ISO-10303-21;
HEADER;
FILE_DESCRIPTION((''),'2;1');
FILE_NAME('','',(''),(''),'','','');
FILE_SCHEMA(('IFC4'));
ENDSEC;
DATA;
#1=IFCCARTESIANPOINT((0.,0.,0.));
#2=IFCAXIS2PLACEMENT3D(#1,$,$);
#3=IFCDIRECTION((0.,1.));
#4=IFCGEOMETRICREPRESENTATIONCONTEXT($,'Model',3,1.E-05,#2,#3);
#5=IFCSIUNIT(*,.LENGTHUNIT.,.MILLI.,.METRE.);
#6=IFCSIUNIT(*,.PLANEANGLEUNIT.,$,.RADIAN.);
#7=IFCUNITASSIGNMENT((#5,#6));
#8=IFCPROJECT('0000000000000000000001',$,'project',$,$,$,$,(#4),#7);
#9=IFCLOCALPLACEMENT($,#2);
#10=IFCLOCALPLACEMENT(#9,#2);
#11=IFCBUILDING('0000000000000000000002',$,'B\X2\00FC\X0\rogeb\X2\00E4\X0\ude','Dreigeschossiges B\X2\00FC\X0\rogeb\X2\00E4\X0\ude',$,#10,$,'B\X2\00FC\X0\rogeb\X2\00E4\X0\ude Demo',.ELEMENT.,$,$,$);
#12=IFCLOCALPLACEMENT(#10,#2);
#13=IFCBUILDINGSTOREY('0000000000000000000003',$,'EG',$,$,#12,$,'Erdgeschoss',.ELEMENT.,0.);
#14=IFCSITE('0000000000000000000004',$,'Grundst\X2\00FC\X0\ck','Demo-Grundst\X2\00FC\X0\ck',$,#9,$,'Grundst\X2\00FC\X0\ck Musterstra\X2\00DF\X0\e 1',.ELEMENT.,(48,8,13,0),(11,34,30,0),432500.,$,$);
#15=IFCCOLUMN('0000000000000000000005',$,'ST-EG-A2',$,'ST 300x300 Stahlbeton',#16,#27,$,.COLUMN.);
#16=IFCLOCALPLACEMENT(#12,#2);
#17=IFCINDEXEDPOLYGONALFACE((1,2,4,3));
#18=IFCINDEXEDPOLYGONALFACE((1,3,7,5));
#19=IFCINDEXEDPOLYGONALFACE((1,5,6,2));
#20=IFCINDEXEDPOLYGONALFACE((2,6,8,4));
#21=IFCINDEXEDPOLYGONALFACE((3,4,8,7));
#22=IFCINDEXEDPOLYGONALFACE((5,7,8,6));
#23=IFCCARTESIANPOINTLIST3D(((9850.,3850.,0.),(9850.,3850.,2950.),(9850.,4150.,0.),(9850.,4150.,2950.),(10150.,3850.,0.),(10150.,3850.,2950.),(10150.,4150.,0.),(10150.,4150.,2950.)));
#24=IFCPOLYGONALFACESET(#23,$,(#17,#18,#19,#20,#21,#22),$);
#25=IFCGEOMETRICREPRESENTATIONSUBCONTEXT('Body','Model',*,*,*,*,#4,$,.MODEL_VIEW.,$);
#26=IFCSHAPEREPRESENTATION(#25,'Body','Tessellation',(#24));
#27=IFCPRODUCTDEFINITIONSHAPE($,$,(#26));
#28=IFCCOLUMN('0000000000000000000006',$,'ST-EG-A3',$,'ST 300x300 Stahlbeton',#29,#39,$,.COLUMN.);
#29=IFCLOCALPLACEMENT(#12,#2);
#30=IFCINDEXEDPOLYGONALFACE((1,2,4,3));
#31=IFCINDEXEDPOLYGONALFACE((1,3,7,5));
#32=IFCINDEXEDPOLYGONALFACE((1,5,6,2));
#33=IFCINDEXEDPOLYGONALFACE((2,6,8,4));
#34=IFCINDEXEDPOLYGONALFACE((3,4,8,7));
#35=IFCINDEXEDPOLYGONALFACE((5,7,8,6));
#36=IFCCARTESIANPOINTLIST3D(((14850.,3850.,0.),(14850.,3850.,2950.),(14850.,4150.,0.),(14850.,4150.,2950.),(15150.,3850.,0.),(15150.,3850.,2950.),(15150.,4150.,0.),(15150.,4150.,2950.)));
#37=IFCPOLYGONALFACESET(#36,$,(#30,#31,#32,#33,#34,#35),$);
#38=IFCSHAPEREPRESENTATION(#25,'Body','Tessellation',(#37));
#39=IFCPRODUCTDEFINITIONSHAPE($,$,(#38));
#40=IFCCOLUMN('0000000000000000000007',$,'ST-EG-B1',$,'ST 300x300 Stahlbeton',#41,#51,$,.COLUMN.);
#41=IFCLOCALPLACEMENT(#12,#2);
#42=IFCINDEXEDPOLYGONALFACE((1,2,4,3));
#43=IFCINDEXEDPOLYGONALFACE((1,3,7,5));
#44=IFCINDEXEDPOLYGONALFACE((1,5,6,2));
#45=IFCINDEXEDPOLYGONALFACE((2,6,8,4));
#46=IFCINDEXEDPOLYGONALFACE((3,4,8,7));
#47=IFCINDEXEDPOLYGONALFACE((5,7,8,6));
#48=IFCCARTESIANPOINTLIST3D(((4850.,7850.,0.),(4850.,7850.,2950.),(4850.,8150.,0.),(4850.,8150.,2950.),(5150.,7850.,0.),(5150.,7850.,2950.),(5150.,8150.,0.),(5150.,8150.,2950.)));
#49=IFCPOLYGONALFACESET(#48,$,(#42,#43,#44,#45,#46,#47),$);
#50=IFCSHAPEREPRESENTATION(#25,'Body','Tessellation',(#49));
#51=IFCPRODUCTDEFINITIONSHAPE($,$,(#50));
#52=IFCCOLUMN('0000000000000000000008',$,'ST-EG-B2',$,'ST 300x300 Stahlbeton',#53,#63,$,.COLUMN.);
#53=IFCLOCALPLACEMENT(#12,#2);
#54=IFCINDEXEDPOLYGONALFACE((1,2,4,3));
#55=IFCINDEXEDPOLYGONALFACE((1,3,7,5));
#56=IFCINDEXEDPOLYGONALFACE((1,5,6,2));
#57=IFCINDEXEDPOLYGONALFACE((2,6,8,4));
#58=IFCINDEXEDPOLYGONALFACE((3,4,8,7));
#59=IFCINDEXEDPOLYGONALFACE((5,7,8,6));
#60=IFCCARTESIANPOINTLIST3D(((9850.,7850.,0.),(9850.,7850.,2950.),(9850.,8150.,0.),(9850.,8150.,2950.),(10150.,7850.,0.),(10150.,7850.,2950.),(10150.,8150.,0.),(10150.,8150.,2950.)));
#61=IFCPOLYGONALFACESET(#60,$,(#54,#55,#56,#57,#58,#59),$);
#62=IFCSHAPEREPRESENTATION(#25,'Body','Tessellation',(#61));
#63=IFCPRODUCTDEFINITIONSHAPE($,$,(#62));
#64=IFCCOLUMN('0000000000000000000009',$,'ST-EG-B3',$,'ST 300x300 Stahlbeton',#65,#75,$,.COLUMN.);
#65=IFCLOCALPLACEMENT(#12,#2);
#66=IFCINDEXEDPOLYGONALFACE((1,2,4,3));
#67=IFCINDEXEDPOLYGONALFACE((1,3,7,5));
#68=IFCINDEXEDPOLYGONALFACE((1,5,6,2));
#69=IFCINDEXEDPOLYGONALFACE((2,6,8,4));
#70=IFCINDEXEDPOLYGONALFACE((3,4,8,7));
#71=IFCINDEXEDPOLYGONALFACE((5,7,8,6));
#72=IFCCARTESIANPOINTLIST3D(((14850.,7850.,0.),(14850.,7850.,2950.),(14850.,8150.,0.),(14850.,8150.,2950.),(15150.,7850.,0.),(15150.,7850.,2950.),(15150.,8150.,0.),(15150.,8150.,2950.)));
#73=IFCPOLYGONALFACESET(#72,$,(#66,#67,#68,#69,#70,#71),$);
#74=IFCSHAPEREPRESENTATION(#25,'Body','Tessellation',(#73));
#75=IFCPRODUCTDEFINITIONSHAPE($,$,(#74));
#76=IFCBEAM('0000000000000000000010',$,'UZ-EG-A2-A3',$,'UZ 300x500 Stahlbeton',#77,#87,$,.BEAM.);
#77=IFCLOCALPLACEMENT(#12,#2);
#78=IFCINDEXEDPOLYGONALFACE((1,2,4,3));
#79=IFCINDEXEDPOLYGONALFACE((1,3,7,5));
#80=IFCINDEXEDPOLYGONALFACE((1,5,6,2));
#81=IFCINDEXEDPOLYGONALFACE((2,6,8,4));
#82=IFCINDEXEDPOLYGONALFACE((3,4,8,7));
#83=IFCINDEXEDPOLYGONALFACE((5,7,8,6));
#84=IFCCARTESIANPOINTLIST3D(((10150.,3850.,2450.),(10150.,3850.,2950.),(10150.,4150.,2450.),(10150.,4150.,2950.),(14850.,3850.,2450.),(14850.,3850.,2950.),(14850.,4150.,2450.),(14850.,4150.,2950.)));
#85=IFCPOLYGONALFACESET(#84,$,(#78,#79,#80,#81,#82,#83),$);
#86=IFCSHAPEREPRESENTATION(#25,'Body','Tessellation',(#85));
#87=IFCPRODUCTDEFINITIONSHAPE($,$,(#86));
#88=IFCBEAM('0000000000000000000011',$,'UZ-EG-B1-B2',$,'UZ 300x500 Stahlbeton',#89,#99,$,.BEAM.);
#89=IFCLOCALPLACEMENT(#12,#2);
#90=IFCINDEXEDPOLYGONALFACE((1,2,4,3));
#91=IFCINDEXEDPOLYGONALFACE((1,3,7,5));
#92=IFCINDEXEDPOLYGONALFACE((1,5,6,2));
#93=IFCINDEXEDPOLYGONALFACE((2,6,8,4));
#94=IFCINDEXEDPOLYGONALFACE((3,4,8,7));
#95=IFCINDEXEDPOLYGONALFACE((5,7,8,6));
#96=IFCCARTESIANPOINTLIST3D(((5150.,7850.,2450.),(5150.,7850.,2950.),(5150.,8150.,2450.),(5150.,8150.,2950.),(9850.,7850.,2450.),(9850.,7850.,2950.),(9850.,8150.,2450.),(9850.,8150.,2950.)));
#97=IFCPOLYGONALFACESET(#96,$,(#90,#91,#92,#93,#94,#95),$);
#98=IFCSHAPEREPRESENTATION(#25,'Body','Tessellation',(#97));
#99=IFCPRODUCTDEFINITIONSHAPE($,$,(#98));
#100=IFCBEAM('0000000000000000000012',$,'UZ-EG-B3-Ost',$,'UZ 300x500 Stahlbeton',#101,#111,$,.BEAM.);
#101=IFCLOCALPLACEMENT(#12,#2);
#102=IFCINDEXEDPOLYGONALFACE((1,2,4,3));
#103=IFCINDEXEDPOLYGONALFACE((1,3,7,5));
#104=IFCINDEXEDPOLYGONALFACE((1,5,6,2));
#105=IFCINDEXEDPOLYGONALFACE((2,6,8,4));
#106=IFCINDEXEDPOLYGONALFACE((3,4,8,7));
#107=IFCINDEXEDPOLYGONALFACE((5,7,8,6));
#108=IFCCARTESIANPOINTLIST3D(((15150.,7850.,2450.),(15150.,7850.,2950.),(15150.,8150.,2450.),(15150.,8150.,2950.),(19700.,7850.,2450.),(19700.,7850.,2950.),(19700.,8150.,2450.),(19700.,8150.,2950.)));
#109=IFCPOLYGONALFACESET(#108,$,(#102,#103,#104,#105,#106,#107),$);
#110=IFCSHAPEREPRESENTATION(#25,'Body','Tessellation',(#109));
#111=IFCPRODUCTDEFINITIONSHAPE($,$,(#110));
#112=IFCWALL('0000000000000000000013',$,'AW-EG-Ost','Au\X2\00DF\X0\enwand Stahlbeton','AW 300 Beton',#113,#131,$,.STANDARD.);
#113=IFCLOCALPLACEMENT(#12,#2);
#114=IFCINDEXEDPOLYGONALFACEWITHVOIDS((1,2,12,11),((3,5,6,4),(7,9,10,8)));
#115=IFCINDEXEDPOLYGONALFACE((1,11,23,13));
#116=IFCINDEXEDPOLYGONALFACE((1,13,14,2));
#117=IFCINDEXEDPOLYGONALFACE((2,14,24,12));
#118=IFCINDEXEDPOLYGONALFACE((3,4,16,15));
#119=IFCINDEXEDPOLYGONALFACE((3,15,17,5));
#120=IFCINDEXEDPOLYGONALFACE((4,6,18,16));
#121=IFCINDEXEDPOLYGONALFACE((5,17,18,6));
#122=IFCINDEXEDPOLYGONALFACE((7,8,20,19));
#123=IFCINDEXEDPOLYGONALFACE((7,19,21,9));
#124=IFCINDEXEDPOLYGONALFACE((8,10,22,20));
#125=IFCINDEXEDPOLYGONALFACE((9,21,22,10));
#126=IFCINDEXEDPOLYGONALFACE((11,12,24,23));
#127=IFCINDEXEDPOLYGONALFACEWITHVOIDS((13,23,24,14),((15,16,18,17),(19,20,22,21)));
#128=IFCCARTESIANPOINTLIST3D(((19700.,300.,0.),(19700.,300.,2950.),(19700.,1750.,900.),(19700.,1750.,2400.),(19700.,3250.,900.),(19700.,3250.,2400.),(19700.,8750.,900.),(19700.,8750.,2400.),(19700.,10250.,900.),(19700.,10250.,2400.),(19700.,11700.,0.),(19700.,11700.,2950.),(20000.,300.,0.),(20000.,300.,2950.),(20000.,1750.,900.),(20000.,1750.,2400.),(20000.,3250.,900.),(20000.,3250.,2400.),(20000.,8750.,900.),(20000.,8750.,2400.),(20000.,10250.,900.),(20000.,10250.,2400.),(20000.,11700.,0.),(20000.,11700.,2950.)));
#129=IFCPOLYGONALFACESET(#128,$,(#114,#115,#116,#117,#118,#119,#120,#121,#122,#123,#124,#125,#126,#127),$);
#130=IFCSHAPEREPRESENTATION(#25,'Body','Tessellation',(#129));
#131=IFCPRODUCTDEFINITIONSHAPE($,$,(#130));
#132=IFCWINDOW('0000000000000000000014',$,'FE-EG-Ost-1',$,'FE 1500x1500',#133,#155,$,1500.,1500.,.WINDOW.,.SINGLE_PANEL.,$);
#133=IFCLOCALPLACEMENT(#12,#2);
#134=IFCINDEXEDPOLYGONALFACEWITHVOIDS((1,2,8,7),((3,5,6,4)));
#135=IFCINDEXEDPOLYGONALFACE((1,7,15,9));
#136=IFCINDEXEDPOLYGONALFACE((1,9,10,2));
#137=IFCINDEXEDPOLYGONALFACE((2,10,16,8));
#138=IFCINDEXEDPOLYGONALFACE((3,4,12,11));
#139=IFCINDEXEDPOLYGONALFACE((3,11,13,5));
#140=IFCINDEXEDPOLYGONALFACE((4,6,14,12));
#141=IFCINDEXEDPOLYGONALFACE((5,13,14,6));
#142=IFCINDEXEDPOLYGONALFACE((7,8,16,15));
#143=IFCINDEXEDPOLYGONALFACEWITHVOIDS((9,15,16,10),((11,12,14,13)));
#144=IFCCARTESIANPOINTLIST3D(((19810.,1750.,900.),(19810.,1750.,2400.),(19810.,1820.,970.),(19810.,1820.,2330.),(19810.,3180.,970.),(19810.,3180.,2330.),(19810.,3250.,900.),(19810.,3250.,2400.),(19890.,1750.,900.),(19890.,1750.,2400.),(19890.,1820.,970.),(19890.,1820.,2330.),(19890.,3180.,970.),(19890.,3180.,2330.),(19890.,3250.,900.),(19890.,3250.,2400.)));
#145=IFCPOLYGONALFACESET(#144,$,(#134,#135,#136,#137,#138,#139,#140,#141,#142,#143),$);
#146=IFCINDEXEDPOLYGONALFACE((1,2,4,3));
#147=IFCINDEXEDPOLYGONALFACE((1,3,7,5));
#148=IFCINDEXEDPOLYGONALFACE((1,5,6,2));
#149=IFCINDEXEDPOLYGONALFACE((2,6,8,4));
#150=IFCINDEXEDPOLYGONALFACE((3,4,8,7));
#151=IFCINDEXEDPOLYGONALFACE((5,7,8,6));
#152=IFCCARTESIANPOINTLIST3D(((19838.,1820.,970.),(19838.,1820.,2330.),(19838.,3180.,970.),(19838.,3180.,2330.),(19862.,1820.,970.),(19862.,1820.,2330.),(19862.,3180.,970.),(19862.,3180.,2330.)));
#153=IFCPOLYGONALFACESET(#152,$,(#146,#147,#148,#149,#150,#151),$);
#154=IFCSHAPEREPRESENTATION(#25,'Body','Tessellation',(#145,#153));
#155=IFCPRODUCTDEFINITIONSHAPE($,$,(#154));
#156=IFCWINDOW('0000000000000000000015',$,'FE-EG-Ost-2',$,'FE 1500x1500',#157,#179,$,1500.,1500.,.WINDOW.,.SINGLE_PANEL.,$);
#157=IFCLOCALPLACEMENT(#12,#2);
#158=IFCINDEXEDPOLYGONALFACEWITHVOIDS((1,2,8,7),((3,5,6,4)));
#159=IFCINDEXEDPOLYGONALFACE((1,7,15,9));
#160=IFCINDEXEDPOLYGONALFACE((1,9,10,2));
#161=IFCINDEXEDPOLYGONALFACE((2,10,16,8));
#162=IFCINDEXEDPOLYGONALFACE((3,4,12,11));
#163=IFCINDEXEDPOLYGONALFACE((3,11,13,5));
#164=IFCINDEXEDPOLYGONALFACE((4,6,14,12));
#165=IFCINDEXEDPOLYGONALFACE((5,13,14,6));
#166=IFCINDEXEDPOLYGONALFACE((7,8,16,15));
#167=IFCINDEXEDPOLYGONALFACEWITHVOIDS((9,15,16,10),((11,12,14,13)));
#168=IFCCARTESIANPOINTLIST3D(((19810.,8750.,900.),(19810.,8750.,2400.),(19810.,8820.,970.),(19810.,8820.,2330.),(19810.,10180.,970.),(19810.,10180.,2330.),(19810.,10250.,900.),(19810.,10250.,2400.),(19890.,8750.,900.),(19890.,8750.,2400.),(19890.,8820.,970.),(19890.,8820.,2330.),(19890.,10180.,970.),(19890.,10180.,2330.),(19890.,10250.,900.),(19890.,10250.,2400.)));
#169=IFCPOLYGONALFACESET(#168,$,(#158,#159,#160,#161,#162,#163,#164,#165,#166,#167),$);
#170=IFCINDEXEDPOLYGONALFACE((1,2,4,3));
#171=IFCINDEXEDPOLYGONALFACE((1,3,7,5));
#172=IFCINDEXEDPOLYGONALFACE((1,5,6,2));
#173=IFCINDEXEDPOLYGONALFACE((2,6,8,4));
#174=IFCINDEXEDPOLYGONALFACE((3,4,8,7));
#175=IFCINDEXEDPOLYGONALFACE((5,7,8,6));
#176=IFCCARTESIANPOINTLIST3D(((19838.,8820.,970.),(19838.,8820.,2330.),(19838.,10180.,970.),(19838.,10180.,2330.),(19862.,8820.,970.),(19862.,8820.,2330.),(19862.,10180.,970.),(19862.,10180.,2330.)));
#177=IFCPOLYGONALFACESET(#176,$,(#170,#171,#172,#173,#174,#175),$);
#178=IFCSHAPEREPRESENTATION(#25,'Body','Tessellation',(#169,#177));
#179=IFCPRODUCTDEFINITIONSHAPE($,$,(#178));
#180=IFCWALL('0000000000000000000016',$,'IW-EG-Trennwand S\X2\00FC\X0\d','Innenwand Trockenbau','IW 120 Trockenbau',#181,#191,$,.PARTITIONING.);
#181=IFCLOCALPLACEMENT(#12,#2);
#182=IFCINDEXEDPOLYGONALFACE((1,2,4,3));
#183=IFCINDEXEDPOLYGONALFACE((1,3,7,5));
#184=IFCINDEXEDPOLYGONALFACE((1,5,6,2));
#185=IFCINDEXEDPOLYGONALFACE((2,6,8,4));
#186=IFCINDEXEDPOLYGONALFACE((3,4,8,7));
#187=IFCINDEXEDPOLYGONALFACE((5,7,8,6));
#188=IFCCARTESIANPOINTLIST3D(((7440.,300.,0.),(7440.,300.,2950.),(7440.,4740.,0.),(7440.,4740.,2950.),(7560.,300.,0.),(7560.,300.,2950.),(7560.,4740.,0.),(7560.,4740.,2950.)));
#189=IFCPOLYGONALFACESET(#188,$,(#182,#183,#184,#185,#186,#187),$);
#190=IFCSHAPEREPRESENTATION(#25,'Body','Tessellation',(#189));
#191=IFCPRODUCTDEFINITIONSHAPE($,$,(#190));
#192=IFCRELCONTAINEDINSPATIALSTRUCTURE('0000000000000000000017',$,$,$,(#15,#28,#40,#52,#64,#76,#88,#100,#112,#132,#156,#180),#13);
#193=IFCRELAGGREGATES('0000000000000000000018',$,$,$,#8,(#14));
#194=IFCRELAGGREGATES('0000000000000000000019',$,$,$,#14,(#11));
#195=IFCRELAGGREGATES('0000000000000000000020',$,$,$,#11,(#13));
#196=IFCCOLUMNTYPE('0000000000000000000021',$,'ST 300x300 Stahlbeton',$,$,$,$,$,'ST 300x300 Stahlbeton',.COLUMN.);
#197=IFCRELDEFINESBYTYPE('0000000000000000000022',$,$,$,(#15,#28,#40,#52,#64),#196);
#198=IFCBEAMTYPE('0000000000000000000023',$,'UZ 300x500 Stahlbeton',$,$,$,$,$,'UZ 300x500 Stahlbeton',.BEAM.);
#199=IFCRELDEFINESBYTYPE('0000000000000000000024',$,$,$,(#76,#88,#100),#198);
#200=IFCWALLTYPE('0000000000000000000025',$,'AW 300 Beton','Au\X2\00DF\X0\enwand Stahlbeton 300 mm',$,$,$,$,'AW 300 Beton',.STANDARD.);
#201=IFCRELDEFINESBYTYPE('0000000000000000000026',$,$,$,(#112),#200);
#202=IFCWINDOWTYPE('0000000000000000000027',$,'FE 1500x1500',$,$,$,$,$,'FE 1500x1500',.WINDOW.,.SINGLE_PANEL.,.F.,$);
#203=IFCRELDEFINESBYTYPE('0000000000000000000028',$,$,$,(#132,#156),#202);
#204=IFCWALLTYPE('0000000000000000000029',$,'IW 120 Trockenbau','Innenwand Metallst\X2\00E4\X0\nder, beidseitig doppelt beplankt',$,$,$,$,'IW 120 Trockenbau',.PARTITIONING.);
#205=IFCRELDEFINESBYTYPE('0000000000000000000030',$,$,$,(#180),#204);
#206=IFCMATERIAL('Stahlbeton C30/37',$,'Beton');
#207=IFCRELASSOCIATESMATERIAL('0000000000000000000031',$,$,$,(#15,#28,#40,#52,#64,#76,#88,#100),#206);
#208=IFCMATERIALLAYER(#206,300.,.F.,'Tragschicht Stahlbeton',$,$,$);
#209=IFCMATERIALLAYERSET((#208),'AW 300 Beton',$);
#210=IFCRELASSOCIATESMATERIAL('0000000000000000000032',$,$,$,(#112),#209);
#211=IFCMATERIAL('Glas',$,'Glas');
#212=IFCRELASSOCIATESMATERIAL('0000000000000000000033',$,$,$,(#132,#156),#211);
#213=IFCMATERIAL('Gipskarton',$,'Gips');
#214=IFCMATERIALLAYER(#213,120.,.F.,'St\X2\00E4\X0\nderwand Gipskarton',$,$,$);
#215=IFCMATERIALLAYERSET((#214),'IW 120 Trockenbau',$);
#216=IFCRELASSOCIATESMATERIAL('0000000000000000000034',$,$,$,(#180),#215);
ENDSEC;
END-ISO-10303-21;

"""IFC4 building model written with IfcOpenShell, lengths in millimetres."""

from ifc_helpers import new_model, si_unit, direction, frame, frame_2d, origin, origin_2d, place, context, subcontext, project, spatial, polyline, rectangle, outline, extrude, material, layer, layer_set, layer_usage, type_object, element, fill, save


model = new_model("IFC4")

# Units and contexts
model_context = context("Model", 3, precision=1e-05, world=origin(), true_north=direction((0.0, 1.0)))
body_context = subcontext(model_context, "Body", "Model", "MODEL_VIEW")
ifc_project = project(units=[si_unit("LENGTHUNIT", "METRE", prefix="MILLI"), si_unit("PLANEANGLEUNIT", "RADIAN")], contexts=[model_context])

# Site, building, storey
site_placement = place(None, origin())
site = spatial("IfcSite", under=ifc_project, at=site_placement, Name="Grundstück", Description="Demo-Grundstück", LongName="Grundstück Musterstraße 1", CompositionType="ELEMENT", RefLatitude=(48, 8, 13, 0), RefLongitude=(11, 34, 30, 0), RefElevation=432500.0)
building_placement = place(site_placement, origin())
building = spatial("IfcBuilding", under=site, at=building_placement, Name="Bürogebäude", Description="Dreigeschossiges Bürogebäude", LongName="Bürogebäude Demo", CompositionType="ELEMENT")
storey_placement = place(building_placement, origin())
storey = spatial("IfcBuildingStorey", under=building, at=storey_placement, Name="EG", LongName="Erdgeschoss", CompositionType="ELEMENT", Elevation=0.0)

# Columns
ifc_material_1 = material(Name="Stahlbeton C30/37", Category="Beton")
column_type = type_object("IfcColumnType", Name="ST 300x300 Stahlbeton", ElementType="ST 300x300 Stahlbeton", PredefinedType="COLUMN")
for number, where, name in (
    (1, (10000.0, 4000.0, 0.0), "ST-EG-A2"),
    (2, (15000.0, 4000.0, 0.0), "ST-EG-A3"),
    (3, (5000.0, 8000.0, 0.0), "ST-EG-B1"),
    (4, (10000.0, 8000.0, 0.0), "ST-EG-B2"),
    (5, (15000.0, 8000.0, 0.0), "ST-EG-B3"),
):
    element("IfcColumn", number, at=place(storey_placement, frame(where)), inside=storey, type_object=column_type, material=ifc_material_1, Name=name, ObjectType="ST 300x300 Stahlbeton", PredefinedType="COLUMN", context=body_context, shape_type="SweptSolid", body=[
        extrude(rectangle(XDim=300.0, YDim=300.0, at=origin_2d()), origin(), (0.0, 0.0, 1.0), 2950.0),
    ])

# Beams
beam_type = type_object("IfcBeamType", Name="UZ 300x500 Stahlbeton", ElementType="UZ 300x500 Stahlbeton", PredefinedType="BEAM")
for number, where, name in (
    (6, (10150.0, 4000.0, 2700.0), "UZ-EG-A2-A3"),
    (7, (5150.0, 8000.0, 2700.0), "UZ-EG-B1-B2"),
):
    element("IfcBeam", number, at=place(storey_placement, frame(where)), inside=storey, type_object=beam_type, material=ifc_material_1, Name=name, ObjectType="UZ 300x500 Stahlbeton", PredefinedType="BEAM", context=body_context, shape_type="SweptSolid", body=[
        extrude(rectangle(XDim=300.0, YDim=500.0, at=origin_2d()), frame((0.0, 0.0, 0.0), z_axis=(1.0, 0.0, 0.0), x_axis=(0.0, 1.0, 0.0)), (0.0, 0.0, 1.0), 4700.0),
    ])
beam_placement = place(storey_placement, frame((15150.0, 8000.0, 2700.0)))
element("IfcBeam", 8, at=beam_placement, inside=storey, type_object=beam_type, material=ifc_material_1, Name="UZ-EG-B3-Ost", ObjectType="UZ 300x500 Stahlbeton", PredefinedType="BEAM", context=body_context, shape_type="SweptSolid", body=[
    extrude(rectangle(XDim=300.0, YDim=500.0, at=origin_2d()), frame((0.0, 0.0, 0.0), z_axis=(1.0, 0.0, 0.0), x_axis=(0.0, 1.0, 0.0)), (0.0, 0.0, 1.0), 4550.0),
])

# Wall, openings, windows
ifc_layer_1 = layer(ifc_material_1, 300.0, ventilated=False, Name="Tragschicht Stahlbeton")
ifc_layer_set_1 = layer_set([ifc_layer_1], Name="AW 300 Beton")
ifc_layer_usage_1 = layer_usage(ifc_layer_set_1, "AXIS2", "POSITIVE", -150.0)
wall_type_1 = type_object("IfcWallType", Name="AW 300 Beton", Description="Außenwand Stahlbeton 300 mm", ElementType="AW 300 Beton", PredefinedType="STANDARD")
wall_placement = place(storey_placement, frame((19850.0, 300.0, 0.0), z_axis=(0.0, 0.0, 1.0), x_axis=(0.0, 1.0, 0.0)))
wall = element("IfcWall", 9, at=wall_placement, inside=storey, type_object=wall_type_1, material=ifc_layer_usage_1, Name="AW-EG-Ost", Description="Außenwand Stahlbeton", ObjectType="AW 300 Beton", PredefinedType="STANDARD", context=body_context, shape_type="SweptSolid", body=[
    extrude(rectangle(XDim=11400.0, YDim=300.0, at=frame_2d((5700.0, 0.0))), origin(), (0.0, 0.0, 1.0), 2950.0),
])
opening_1_placement = place(wall_placement, frame((2200.0, 0.0, 900.0)))
opening_1 = element("IfcOpeningElement", 10, at=opening_1_placement, cuts=wall, PredefinedType="OPENING", context=body_context, shape_type="SweptSolid", body=[
    extrude(rectangle(XDim=1500.0, YDim=340.0, at=origin_2d()), origin(), (0.0, 0.0, 1.0), 1500.0),
])
opening_2_placement = place(wall_placement, frame((9200.0, 0.0, 900.0)))
opening_2 = element("IfcOpeningElement", 11, at=opening_2_placement, cuts=wall, PredefinedType="OPENING", context=body_context, shape_type="SweptSolid", body=[
    extrude(rectangle(XDim=1500.0, YDim=340.0, at=origin_2d()), origin(), (0.0, 0.0, 1.0), 1500.0),
])
ifc_material_2 = material(Name="Glas", Category="Glas")
window_type = type_object("IfcWindowType", Name="FE 1500x1500", ElementType="FE 1500x1500", ParameterTakesPrecedence=False, PartitioningType="SINGLE_PANEL", PredefinedType="WINDOW")
window_1_placement = place(opening_1_placement, origin())
window_1 = element("IfcWindow", 12, at=window_1_placement, inside=storey, type_object=window_type, material=ifc_material_2, Name="FE-EG-Ost-1", ObjectType="FE 1500x1500", OverallHeight=1500.0, OverallWidth=1500.0, PartitioningType="SINGLE_PANEL", PredefinedType="WINDOW", context=body_context, shape_type="SweptSolid", body=[
    extrude(outline(polyline([(-750.0, 0.0), (750.0, 0.0), (750.0, 1500.0), (-750.0, 1500.0), (-750.0, 0.0)]), holes=[polyline([(-680.0, 70.0), (680.0, 70.0), (680.0, 1430.0), (-680.0, 1430.0), (-680.0, 70.0)])]), frame((0.0, 40.0, 0.0), z_axis=(0.0, -1.0, 0.0), x_axis=(1.0, 0.0, 0.0)), (0.0, 0.0, 1.0), 80.0),
    extrude(rectangle(XDim=1360.0, YDim=24.0, at=origin_2d()), frame((0.0, 0.0, 70.0)), (0.0, 0.0, 1.0), 1360.0),
])
fill(opening_1, window_1)
window_2_placement = place(opening_2_placement, origin())
window_2 = element("IfcWindow", 13, at=window_2_placement, inside=storey, type_object=window_type, material=ifc_material_2, Name="FE-EG-Ost-2", ObjectType="FE 1500x1500", OverallHeight=1500.0, OverallWidth=1500.0, PartitioningType="SINGLE_PANEL", PredefinedType="WINDOW", context=body_context, shape_type="SweptSolid", body=[
    extrude(outline(polyline([(-750.0, 0.0), (750.0, 0.0), (750.0, 1500.0), (-750.0, 1500.0), (-750.0, 0.0)]), holes=[polyline([(-680.0, 70.0), (680.0, 70.0), (680.0, 1430.0), (-680.0, 1430.0), (-680.0, 70.0)])]), frame((0.0, 40.0, 0.0), z_axis=(0.0, -1.0, 0.0), x_axis=(1.0, 0.0, 0.0)), (0.0, 0.0, 1.0), 80.0),
    extrude(rectangle(XDim=1360.0, YDim=24.0, at=origin_2d()), frame((0.0, 0.0, 70.0)), (0.0, 0.0, 1.0), 1360.0),
])
fill(opening_2, window_2)

# Wall
ifc_material_3 = material(Name="Gipskarton", Category="Gips")
ifc_layer_2 = layer(ifc_material_3, 120.0, ventilated=False, Name="Ständerwand Gipskarton")
ifc_layer_set_2 = layer_set([ifc_layer_2], Name="IW 120 Trockenbau")
ifc_layer_usage_2 = layer_usage(ifc_layer_set_2, "AXIS2", "POSITIVE", -60.0)
wall_type_2 = type_object("IfcWallType", Name="IW 120 Trockenbau", Description="Innenwand Metallständer, beidseitig doppelt beplankt", ElementType="IW 120 Trockenbau", PredefinedType="PARTITIONING")
for number, where, z_axis, x_axis, name in (
    (14, (7500.0, 300.0, 0.0), (0.0, 0.0, 1.0), (0.0, 1.0, 0.0), "IW-EG-Trennwand Süd"),
):
    element("IfcWall", number, at=place(storey_placement, frame(where, z_axis=z_axis, x_axis=x_axis)), inside=storey, type_object=wall_type_2, material=ifc_layer_usage_2, Name=name, Description="Innenwand Trockenbau", ObjectType="IW 120 Trockenbau", PredefinedType="PARTITIONING", context=body_context, shape_type="SweptSolid", body=[
        extrude(rectangle(XDim=4440.0, YDim=120.0, at=frame_2d((2220.0, 0.0))), origin(), (0.0, 0.0, 1.0), 2950.0),
    ])

save(model, "model.ifc")
